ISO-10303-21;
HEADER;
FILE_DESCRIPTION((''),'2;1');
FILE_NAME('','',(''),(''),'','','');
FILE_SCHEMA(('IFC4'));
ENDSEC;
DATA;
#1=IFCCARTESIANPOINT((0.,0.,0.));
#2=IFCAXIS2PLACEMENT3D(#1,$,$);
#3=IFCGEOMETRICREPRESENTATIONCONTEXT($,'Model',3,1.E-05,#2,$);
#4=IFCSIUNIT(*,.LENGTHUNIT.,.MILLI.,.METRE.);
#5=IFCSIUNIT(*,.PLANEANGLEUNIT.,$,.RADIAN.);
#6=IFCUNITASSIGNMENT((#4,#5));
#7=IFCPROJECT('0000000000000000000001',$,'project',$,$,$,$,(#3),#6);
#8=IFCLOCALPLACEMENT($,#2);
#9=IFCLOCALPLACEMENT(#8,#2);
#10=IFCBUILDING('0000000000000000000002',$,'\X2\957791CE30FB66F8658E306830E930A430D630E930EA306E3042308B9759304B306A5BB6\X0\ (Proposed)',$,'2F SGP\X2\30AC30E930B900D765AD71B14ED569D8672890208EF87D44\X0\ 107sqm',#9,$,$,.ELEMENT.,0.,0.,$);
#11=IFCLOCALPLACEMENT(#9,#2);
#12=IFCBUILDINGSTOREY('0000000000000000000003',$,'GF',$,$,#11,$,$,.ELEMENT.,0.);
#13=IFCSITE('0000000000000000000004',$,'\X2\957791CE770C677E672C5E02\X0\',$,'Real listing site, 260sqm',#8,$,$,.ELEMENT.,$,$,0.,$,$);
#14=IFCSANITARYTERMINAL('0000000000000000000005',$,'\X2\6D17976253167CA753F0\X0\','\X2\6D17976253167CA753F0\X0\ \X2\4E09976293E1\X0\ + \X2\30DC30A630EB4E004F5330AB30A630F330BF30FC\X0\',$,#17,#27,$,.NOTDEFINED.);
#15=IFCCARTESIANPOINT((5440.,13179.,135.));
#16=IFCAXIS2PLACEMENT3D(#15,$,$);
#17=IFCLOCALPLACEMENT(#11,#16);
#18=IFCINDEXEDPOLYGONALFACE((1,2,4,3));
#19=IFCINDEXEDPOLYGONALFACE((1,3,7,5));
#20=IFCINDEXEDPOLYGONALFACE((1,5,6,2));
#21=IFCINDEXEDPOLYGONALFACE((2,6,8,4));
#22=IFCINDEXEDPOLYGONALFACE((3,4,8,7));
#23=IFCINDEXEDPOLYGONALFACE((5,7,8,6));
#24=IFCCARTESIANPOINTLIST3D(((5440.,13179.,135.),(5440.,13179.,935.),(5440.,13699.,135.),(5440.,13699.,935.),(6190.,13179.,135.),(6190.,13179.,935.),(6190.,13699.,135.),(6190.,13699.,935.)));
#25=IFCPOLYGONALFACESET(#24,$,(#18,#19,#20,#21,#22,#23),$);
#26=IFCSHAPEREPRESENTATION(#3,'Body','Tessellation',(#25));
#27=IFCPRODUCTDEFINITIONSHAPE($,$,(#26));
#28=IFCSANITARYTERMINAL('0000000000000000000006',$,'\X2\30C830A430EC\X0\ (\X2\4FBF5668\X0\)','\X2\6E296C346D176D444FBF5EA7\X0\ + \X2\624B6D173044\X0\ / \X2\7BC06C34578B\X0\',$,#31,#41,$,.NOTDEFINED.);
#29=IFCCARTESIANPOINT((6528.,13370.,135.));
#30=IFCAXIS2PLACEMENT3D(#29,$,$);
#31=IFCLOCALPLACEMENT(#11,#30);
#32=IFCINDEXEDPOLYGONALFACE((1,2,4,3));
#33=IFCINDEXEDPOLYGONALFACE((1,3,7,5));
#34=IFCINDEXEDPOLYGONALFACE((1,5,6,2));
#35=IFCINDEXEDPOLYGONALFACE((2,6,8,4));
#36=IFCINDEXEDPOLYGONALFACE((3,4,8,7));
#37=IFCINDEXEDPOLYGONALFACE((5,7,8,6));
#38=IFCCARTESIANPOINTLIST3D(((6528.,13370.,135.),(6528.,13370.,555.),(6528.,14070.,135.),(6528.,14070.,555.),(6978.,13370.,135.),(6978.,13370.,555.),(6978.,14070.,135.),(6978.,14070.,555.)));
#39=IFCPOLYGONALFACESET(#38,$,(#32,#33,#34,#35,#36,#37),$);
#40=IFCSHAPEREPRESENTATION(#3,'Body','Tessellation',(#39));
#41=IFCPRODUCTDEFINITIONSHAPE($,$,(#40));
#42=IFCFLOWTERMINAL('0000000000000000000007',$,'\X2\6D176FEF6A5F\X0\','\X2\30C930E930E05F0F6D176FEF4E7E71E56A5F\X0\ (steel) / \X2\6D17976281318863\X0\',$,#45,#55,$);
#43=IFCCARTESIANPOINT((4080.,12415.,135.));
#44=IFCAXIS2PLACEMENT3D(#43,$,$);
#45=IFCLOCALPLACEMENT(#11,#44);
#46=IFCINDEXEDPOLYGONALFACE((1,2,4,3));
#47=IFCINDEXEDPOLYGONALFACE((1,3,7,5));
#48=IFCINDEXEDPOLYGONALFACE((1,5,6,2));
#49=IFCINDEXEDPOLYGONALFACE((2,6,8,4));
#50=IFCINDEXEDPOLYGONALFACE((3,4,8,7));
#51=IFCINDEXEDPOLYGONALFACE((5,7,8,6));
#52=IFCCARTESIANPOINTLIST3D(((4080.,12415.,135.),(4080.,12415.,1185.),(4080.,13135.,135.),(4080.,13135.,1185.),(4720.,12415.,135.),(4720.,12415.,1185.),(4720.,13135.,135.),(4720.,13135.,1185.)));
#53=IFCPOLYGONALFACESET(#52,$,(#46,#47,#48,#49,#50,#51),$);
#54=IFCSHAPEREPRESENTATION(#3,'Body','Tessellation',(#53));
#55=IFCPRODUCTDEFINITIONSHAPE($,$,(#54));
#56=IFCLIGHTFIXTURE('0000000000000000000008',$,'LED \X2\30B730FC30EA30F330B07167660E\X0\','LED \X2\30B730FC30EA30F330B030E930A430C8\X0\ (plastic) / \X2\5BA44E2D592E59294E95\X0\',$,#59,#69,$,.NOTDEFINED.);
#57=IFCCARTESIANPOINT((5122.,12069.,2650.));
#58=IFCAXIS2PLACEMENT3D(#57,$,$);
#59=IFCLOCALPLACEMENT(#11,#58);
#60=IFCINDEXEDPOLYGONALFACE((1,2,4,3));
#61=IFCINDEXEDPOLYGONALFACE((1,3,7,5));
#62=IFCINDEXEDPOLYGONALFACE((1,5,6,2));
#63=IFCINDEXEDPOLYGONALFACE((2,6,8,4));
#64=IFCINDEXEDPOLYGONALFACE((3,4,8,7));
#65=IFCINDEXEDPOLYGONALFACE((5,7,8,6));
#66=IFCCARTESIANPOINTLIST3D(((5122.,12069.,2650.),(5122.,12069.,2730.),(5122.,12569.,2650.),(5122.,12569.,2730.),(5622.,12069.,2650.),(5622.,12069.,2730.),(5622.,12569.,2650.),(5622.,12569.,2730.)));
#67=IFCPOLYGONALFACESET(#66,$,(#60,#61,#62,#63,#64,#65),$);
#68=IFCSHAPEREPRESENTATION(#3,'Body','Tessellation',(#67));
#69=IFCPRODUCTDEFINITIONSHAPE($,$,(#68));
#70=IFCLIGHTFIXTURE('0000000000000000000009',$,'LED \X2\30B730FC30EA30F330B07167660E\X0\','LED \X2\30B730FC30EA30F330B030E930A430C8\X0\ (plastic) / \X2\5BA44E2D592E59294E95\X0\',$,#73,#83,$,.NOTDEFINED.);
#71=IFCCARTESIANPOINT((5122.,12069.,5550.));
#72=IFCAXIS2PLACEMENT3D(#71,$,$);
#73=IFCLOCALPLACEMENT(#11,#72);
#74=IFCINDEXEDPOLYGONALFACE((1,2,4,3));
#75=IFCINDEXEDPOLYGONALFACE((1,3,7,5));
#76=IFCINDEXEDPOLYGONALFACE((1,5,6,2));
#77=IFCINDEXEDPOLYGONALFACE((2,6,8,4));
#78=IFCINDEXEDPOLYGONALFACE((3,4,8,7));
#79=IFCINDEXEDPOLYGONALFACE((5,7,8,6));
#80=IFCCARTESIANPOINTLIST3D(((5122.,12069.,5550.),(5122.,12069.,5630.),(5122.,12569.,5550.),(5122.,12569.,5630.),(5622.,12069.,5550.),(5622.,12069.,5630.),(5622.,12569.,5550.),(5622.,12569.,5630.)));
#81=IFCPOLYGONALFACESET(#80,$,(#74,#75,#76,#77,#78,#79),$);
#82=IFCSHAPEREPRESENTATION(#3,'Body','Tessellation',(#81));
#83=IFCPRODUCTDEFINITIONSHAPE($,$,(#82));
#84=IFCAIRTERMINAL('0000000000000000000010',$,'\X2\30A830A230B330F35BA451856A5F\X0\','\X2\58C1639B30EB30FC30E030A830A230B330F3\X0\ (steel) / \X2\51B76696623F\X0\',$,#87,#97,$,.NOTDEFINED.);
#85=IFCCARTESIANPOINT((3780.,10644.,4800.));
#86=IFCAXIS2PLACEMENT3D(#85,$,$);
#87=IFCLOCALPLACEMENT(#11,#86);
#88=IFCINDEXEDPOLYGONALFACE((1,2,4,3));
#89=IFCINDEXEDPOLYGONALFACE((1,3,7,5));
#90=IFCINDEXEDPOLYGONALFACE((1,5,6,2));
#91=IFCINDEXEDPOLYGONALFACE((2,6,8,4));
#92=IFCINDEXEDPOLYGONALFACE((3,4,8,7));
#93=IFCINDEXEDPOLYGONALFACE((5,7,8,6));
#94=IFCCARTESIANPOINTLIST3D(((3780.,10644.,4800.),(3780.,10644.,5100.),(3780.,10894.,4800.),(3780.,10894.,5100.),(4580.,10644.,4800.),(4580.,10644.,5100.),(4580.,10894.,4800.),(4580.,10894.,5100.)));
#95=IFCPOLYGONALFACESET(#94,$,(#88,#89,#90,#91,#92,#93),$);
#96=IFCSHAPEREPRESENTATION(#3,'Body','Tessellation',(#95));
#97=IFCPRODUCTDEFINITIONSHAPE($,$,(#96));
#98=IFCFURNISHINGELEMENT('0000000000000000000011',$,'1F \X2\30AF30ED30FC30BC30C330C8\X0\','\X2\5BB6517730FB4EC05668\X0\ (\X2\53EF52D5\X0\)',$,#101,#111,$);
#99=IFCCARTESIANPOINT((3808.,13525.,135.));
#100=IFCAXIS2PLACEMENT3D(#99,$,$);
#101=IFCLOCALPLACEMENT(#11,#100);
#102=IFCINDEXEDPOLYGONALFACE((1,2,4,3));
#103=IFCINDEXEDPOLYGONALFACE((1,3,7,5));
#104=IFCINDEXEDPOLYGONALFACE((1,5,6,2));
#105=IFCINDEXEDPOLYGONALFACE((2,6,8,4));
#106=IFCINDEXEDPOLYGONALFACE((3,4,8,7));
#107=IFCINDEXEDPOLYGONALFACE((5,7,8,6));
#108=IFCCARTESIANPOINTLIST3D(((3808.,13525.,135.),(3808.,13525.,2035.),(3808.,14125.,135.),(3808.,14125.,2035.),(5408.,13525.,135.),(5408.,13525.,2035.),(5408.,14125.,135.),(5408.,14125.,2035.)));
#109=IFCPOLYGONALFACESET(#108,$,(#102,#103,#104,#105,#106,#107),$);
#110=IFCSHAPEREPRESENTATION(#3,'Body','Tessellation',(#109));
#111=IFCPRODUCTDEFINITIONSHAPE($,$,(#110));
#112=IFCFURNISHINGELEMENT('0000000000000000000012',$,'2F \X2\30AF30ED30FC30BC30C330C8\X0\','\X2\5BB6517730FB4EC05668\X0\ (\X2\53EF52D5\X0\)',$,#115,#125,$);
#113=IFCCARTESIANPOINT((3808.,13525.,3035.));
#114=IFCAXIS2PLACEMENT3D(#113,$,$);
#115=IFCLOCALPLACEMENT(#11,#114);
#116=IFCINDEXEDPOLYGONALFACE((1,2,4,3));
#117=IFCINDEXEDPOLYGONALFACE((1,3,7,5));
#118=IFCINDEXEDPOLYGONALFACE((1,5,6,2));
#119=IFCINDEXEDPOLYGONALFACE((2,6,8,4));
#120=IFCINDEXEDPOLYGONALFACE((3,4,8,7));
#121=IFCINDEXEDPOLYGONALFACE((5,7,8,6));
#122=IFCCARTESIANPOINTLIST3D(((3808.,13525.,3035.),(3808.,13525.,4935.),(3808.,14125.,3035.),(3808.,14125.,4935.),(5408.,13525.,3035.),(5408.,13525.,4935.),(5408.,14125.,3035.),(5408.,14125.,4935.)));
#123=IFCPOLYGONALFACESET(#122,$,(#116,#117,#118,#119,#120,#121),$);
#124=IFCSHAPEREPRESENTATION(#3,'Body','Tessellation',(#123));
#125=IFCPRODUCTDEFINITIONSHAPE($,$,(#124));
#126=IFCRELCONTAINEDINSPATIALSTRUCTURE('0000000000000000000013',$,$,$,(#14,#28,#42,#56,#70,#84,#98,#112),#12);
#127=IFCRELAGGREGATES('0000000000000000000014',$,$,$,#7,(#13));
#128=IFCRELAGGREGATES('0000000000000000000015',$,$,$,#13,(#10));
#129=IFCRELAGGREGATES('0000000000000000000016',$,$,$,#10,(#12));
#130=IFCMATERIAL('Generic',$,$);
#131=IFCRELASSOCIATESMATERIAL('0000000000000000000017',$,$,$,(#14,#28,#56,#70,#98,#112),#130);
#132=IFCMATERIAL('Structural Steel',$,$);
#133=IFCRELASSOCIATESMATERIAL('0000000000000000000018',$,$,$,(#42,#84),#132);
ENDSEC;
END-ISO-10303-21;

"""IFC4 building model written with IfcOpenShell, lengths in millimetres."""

from ifc_helpers import new_model, si_unit, frame, frame_2d, origin, place, context, project, spatial, rectangle, extrude, material, element, save


model = new_model("IFC4")

# Units and contexts
model_context = context("Model", 3, precision=1e-05, world=origin())
ifc_project = project(units=[si_unit("LENGTHUNIT", "METRE", prefix="MILLI"), si_unit("PLANEANGLEUNIT", "RADIAN")], contexts=[model_context])

# Site, building, storey
site_placement = place(None, origin())
site = spatial("IfcSite", under=ifc_project, at=site_placement, Name="長野県松本市", ObjectType="Real listing site, 260sqm", CompositionType="ELEMENT", RefElevation=0.0)
building_placement = place(site_placement, origin())
building = spatial("IfcBuilding", under=site, at=building_placement, Name="長野・書斎とライブラリのある静かな家 (Proposed)", ObjectType="2F SGPガラス×断熱仕様木造軸組 107sqm", CompositionType="ELEMENT", ElevationOfRefHeight=0.0, ElevationOfTerrain=0.0)
storey_placement = place(building_placement, origin())
storey = spatial("IfcBuildingStorey", under=building, at=storey_placement, Name="GF", CompositionType="ELEMENT", Elevation=0.0)

# Sanitary terminals
ifc_material_1 = material(Name="Generic")
sanitary_terminal_1_placement = place(storey_placement, frame((5440.0, 13179.0, 135.0)))
element("IfcSanitaryTerminal", 1, at=sanitary_terminal_1_placement, inside=storey, material=ifc_material_1, Name="洗面化粧台", Description="洗面化粧台 三面鏡 + ボウル一体カウンター", PredefinedType="NOTDEFINED", context=model_context, shape_type="SweptSolid", body=[
    extrude(rectangle(XDim=750.0, YDim=520.0, at=frame_2d((375.0, 260.0))), frame((5440.0, 13179.0, 135.0)), (0.0, 0.0, 1.0), 800.0),
])
sanitary_terminal_2_placement = place(storey_placement, frame((6528.0, 13370.0, 135.0)))
element("IfcSanitaryTerminal", 2, at=sanitary_terminal_2_placement, inside=storey, material=ifc_material_1, Name="トイレ (便器)", Description="温水洗浄便座 + 手洗い / 節水型", PredefinedType="NOTDEFINED", context=model_context, shape_type="SweptSolid", body=[
    extrude(rectangle(XDim=450.0, YDim=700.0, at=frame_2d((225.0, 350.0))), frame((6528.0, 13370.0, 135.0)), (0.0, 0.0, 1.0), 420.0),
])

# Flow terminal
ifc_material_2 = material(Name="Structural Steel")
flow_terminal_placement = place(storey_placement, frame((4080.0, 12415.0, 135.0)))
element("IfcFlowTerminal", 3, at=flow_terminal_placement, inside=storey, material=ifc_material_2, Name="洗濯機", Description="ドラム式洗濯乾燥機 (steel) / 洗面脱衣", context=model_context, shape_type="SweptSolid", body=[
    extrude(rectangle(XDim=640.0, YDim=720.0, at=frame_2d((320.0, 360.0))), frame((4080.0, 12415.0, 135.0)), (0.0, 0.0, 1.0), 1050.0),
])

# Light fixtures
light_fixture_1_placement = place(storey_placement, frame((5122.0, 12069.0, 2650.0)))
element("IfcLightFixture", 4, at=light_fixture_1_placement, inside=storey, material=ifc_material_1, Name="LED シーリング照明", Description="LED シーリングライト (plastic) / 室中央天井", PredefinedType="NOTDEFINED", context=model_context, shape_type="SweptSolid", body=[
    extrude(rectangle(XDim=500.0, YDim=500.0, at=frame_2d((250.0, 250.0))), frame((5122.0, 12069.0, 2650.0)), (0.0, 0.0, 1.0), 80.0),
])
light_fixture_2_placement = place(storey_placement, frame((5122.0, 12069.0, 5550.0)))
element("IfcLightFixture", 5, at=light_fixture_2_placement, inside=storey, material=ifc_material_1, Name="LED シーリング照明", Description="LED シーリングライト (plastic) / 室中央天井", PredefinedType="NOTDEFINED", context=model_context, shape_type="SweptSolid", body=[
    extrude(rectangle(XDim=500.0, YDim=500.0, at=frame_2d((250.0, 250.0))), frame((5122.0, 12069.0, 5550.0)), (0.0, 0.0, 1.0), 80.0),
])

# Air terminal
air_terminal_placement = place(storey_placement, frame((3780.0, 10644.0, 4800.0)))
element("IfcAirTerminal", 6, at=air_terminal_placement, inside=storey, material=ifc_material_2, Name="エアコン室内機", Description="壁掛ルームエアコン (steel) / 冷暖房", PredefinedType="NOTDEFINED", context=model_context, shape_type="SweptSolid", body=[
    extrude(rectangle(XDim=800.0, YDim=250.0, at=frame_2d((400.0, 125.0))), frame((3780.0, 10644.0, 4800.0)), (0.0, 0.0, 1.0), 300.0),
])

# Furnishing elements
furnishing_1_placement = place(storey_placement, frame((3808.0, 13525.0, 135.0)))
element("IfcFurnishingElement", 7, at=furnishing_1_placement, inside=storey, material=ifc_material_1, Name="1F クローゼット", Description="家具・什器 (可動)", context=model_context, shape_type="SweptSolid", body=[
    extrude(rectangle(XDim=1600.0, YDim=600.0, at=frame_2d((800.0, 300.0))), frame((3808.0, 13525.0, 135.0)), (0.0, 0.0, 1.0), 1900.0),
])
furnishing_2_placement = place(storey_placement, frame((3808.0, 13525.0, 3035.0)))
element("IfcFurnishingElement", 8, at=furnishing_2_placement, inside=storey, material=ifc_material_1, Name="2F クローゼット", Description="家具・什器 (可動)", context=model_context, shape_type="SweptSolid", body=[
    extrude(rectangle(XDim=1600.0, YDim=600.0, at=frame_2d((800.0, 300.0))), frame((3808.0, 13525.0, 3035.0)), (0.0, 0.0, 1.0), 1900.0),
])

save(model, "model.ifc")
